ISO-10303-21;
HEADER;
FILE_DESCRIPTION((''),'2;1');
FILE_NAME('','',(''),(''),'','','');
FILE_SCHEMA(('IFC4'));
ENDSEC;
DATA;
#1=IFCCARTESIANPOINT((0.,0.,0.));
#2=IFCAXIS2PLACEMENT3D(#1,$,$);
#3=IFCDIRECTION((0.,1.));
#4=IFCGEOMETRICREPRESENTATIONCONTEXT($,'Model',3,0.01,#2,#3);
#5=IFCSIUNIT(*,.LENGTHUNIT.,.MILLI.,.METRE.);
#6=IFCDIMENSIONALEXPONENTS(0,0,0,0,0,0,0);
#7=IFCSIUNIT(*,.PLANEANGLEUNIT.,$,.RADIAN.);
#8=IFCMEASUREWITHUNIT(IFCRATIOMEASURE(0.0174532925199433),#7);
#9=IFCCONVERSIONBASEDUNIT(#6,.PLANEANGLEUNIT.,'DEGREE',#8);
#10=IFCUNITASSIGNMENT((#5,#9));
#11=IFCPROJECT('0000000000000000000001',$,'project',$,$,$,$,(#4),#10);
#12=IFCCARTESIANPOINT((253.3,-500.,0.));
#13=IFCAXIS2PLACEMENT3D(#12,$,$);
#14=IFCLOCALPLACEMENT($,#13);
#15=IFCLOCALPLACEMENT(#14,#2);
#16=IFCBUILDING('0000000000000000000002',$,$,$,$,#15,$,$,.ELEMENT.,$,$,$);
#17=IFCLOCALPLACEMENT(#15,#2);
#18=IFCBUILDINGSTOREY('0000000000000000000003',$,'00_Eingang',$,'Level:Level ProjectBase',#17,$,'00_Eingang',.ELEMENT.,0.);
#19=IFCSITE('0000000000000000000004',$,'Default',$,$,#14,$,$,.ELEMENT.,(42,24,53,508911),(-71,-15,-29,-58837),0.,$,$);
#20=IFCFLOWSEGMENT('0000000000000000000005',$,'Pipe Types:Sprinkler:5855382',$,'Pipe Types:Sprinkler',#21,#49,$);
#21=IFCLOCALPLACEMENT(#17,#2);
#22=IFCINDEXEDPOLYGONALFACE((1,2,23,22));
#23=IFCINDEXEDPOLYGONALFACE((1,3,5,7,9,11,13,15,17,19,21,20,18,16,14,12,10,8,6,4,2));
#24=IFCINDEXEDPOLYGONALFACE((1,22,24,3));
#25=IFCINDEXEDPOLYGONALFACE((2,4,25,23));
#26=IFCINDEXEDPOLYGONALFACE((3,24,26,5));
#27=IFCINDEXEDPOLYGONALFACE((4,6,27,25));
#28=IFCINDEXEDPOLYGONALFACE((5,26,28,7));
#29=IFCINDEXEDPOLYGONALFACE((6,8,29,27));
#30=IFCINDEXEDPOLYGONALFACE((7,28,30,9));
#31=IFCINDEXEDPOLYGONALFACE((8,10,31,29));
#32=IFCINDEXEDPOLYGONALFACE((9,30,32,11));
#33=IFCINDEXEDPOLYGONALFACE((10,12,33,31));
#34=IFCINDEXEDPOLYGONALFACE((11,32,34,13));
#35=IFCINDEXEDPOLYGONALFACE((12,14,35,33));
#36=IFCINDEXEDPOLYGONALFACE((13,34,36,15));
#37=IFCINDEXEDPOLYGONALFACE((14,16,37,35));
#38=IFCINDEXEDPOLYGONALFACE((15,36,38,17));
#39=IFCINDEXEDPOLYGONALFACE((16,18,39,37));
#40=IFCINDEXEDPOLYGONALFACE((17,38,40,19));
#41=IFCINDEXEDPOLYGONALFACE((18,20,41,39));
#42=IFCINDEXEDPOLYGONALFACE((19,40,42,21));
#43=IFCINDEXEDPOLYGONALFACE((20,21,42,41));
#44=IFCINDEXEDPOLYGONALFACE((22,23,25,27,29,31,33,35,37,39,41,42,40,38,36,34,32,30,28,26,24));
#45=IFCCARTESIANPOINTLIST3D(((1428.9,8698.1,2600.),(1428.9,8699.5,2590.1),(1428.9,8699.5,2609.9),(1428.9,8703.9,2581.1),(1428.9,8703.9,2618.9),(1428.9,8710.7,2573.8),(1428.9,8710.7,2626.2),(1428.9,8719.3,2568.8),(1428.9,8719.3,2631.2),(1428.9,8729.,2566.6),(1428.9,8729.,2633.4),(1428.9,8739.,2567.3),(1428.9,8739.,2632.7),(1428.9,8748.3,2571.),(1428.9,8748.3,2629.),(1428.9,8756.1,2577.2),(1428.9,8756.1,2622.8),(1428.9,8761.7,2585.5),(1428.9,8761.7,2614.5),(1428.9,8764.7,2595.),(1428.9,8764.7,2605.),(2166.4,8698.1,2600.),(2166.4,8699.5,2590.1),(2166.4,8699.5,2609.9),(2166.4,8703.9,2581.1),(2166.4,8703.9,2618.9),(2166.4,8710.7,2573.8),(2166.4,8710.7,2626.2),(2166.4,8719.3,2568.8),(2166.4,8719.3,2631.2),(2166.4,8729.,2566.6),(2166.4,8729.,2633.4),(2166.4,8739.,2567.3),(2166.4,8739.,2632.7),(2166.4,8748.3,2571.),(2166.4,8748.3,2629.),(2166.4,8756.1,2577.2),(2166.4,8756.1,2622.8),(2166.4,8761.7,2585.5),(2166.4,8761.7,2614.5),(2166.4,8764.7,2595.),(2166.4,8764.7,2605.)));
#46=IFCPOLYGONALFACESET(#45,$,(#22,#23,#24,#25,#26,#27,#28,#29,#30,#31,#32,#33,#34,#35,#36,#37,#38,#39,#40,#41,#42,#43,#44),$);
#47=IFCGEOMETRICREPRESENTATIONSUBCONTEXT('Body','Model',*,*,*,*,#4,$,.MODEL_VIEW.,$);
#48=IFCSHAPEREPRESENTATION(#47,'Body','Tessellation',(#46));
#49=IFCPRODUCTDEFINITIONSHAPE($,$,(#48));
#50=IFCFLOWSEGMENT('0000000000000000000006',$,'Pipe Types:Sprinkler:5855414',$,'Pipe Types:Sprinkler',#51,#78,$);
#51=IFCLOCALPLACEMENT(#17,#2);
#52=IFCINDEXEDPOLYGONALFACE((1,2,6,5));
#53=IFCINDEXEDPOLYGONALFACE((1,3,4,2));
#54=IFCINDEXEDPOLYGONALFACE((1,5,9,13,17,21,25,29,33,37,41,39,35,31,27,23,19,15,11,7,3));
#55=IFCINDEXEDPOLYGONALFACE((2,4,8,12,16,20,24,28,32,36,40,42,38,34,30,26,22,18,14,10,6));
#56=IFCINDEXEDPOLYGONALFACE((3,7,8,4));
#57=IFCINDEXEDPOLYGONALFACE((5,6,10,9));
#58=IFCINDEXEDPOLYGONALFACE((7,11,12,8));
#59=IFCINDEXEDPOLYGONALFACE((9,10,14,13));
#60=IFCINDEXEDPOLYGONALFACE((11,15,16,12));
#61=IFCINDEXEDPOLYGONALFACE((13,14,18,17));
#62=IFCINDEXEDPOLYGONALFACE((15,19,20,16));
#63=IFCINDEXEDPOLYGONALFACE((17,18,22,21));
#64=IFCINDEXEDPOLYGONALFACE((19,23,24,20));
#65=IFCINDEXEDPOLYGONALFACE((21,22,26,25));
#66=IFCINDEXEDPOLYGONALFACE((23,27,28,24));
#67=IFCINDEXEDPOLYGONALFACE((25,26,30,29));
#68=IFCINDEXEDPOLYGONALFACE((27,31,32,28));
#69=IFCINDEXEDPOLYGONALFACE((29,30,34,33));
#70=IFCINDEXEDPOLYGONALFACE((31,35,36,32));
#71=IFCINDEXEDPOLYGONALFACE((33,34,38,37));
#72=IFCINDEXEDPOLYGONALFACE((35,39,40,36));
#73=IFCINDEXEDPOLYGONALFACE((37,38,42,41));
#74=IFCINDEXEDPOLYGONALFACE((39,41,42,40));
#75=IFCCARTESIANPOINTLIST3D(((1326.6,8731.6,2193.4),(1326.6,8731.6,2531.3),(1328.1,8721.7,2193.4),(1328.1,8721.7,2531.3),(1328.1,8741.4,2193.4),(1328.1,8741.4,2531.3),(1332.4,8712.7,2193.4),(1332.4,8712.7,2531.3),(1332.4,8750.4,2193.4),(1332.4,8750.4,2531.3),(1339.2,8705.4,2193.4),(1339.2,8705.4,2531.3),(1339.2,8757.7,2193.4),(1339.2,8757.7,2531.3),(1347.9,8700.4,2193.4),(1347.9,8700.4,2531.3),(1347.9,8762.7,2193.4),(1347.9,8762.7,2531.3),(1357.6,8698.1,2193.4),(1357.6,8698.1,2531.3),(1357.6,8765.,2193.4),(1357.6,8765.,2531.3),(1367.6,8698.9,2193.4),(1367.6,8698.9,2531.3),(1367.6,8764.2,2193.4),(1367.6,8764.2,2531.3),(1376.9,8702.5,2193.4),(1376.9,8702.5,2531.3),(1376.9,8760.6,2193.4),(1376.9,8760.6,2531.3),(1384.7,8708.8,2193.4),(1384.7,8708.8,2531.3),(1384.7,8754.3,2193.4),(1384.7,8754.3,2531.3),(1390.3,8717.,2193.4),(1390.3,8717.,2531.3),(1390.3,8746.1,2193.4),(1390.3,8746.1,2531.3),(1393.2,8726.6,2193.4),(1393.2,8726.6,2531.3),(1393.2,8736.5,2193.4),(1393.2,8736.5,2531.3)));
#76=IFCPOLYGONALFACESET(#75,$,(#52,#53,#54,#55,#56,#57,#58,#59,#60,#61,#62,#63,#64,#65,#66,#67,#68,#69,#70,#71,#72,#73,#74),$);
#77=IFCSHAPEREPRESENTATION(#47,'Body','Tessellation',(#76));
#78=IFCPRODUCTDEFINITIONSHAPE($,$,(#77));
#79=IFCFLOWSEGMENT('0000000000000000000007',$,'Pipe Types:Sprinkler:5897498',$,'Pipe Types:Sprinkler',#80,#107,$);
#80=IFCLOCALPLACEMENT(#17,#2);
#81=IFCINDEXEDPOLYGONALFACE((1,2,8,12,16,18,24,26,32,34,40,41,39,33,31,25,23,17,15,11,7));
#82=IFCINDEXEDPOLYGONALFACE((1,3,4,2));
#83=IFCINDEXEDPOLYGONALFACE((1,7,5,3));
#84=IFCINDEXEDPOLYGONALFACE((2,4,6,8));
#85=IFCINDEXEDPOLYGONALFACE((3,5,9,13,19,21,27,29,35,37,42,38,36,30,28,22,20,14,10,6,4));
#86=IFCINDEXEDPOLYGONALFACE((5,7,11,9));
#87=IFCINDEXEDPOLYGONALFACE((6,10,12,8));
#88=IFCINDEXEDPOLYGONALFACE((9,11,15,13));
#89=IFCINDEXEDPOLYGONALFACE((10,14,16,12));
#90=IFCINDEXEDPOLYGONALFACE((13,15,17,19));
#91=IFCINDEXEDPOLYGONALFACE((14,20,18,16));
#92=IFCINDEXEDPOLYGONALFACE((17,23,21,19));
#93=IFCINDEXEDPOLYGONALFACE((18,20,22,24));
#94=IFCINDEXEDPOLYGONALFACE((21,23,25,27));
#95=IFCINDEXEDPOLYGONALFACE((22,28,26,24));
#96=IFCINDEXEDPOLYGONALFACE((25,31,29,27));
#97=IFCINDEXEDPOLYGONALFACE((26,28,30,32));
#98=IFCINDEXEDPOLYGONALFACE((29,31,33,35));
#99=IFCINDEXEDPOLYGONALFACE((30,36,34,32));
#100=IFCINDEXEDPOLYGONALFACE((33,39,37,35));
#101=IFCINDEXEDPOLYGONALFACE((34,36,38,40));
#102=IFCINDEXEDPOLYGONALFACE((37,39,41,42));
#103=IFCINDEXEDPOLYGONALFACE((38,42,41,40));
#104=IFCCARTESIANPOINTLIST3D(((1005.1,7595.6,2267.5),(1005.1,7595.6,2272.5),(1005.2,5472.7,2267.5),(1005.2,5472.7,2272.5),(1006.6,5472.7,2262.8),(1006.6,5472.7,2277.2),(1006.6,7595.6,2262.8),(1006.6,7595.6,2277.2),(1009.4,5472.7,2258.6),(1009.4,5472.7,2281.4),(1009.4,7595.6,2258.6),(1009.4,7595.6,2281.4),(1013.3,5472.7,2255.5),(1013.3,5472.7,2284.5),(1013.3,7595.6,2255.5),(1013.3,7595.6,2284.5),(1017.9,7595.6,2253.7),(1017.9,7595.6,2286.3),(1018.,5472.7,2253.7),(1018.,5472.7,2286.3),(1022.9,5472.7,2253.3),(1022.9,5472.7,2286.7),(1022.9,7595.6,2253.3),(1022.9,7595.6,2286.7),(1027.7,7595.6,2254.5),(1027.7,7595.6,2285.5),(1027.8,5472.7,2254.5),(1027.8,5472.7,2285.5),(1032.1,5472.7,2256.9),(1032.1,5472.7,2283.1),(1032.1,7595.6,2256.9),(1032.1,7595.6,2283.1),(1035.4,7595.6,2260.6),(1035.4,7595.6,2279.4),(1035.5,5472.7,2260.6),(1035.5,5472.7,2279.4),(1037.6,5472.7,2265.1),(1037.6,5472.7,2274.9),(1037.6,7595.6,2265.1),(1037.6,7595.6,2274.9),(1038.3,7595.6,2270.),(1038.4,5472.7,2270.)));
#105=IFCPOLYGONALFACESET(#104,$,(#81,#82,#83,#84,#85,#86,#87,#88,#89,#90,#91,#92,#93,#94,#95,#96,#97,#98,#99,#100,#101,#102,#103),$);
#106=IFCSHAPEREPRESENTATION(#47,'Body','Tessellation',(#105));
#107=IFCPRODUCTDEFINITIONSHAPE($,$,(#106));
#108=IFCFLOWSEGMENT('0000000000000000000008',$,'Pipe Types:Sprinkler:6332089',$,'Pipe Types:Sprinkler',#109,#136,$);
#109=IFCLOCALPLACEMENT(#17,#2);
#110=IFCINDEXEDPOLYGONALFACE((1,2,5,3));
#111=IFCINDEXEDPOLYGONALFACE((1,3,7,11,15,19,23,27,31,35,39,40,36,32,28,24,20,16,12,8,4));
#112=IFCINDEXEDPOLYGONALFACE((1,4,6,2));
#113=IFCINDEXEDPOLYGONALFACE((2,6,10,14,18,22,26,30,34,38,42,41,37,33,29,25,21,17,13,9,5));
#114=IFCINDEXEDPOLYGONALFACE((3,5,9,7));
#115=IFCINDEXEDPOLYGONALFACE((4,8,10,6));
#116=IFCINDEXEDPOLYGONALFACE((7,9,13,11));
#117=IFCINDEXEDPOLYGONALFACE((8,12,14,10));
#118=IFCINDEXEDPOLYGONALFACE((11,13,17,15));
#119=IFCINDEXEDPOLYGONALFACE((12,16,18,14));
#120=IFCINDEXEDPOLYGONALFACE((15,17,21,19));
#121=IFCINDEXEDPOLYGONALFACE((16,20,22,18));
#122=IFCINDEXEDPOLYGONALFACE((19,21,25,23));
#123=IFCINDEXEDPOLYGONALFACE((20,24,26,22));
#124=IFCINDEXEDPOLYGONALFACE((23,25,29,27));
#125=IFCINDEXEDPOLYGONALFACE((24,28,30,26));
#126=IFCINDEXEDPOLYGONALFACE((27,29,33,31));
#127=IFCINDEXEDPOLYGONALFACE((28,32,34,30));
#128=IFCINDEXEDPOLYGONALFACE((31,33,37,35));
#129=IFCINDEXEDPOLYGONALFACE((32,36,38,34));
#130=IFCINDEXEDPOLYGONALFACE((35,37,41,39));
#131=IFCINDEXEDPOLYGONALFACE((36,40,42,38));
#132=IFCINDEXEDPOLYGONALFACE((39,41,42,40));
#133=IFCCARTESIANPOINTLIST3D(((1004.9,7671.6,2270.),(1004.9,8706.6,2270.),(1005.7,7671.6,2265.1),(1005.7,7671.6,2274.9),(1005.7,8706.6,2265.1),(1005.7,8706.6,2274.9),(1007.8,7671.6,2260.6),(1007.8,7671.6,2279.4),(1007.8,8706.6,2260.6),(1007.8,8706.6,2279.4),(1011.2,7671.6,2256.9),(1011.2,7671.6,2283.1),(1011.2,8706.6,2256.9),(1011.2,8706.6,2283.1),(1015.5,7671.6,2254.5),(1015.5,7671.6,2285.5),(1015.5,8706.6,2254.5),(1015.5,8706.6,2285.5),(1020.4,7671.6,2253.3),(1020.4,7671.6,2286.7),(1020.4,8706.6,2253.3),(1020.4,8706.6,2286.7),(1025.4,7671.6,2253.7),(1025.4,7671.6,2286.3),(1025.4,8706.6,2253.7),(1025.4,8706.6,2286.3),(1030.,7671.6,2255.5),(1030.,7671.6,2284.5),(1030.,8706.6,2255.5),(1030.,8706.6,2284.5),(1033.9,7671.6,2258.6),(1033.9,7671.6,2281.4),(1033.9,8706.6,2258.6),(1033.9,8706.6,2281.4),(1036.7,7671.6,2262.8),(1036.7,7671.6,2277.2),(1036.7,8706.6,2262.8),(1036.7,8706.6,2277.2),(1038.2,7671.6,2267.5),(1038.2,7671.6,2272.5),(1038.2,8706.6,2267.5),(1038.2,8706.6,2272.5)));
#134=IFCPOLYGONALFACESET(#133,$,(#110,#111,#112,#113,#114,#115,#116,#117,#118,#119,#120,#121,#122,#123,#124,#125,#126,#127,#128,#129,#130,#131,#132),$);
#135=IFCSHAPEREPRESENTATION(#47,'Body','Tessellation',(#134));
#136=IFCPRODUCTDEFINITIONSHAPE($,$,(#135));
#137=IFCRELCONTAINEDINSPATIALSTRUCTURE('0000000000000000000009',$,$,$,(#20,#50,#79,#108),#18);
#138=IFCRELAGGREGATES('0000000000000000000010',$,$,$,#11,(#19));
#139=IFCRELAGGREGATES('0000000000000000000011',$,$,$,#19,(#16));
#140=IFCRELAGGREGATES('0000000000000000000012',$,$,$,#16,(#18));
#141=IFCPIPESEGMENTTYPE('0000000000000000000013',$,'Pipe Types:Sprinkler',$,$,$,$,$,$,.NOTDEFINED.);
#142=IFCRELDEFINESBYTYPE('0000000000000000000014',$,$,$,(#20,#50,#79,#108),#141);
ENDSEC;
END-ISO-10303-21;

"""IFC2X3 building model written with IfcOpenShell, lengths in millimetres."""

from ifc_helpers import new_model, entity, si_unit, converted_unit, direction, frame, frame_2d, origin, origin_2d_with_axis, place, context, subcontext, project, spatial, circle, extrude, type_object, element, save


model = new_model("IFC2X3")

# Units and contexts
model_context = context("Model", 3, precision=0.01, world=origin(), true_north=direction((0.0, 1.0)))
body_context = subcontext(model_context, "Body", "Model", "MODEL_VIEW")
ifc_project = project(units=[si_unit("LENGTHUNIT", "METRE", prefix="MILLI"), converted_unit("PLANEANGLEUNIT", "DEGREE", entity("IfcRatioMeasure", 0.0174532925199433), si_unit("PLANEANGLEUNIT", "RADIAN"), dimensions=[0, 0, 0, 0, 0, 0, 0])], contexts=[model_context])

# Site, building, storey
site_placement = place(None, frame((253.3, -500.0, 0.0)))
site = spatial("IfcSite", under=ifc_project, at=site_placement, Name="Default", CompositionType="ELEMENT", RefLatitude=(42, 24, 53, 508911), RefLongitude=(-71, -15, -29, -58837), RefElevation=0.0)
building_placement = place(site_placement, origin())
building = spatial("IfcBuilding", under=site, at=building_placement, CompositionType="ELEMENT")
storey_placement = place(building_placement, origin())
storey = spatial("IfcBuildingStorey", under=building, at=storey_placement, Name="00_Eingang", ObjectType="Level:Level ProjectBase", LongName="00_Eingang", CompositionType="ELEMENT", Elevation=0.0)

# Flow segments
pipe_segment_type = type_object("IfcPipeSegmentType", Name="Pipe Types:Sprinkler", PredefinedType="NOTDEFINED")
flow_segment_1_placement = place(storey_placement, frame((1428.9, 8696.5, 2564.9)))
element("IfcFlowSegment", 1, at=flow_segment_1_placement, inside=storey, type_object=pipe_segment_type, Name="Pipe Types:Sprinkler:5855382", ObjectType="Pipe Types:Sprinkler", context=body_context, shape_type="SweptSolid", body=[
    extrude(circle(Radius=33.5, at=origin_2d_with_axis()), frame((0.0, 35.1, 35.1), z_axis=(1.0, 0.0, -0.000009), x_axis=(0.0, -1.0, 0.0)), (0.0, 0.0, 1.0), 737.5),
])
flow_segment_2_placement = place(storey_placement, frame((1325.0, 8696.5, 2193.4)))
element("IfcFlowSegment", 2, at=flow_segment_2_placement, inside=storey, type_object=pipe_segment_type, Name="Pipe Types:Sprinkler:5855414", ObjectType="Pipe Types:Sprinkler", context=body_context, shape_type="SweptSolid", body=[
    extrude(circle(Radius=33.5, at=frame_2d((0.0, 0.0), x_axis=(1.0, 0.0))), frame((35.1, 35.1, 0.0), z_axis=(0.000012, 0.0, 1.0), x_axis=(-1.0, 0.0, 0.000012)), (0.0, 0.0, 1.0), 337.9),
])
flow_segment_3_placement = place(storey_placement, frame((1003.4, 5472.7, 2251.7)))
element("IfcFlowSegment", 3, at=flow_segment_3_placement, inside=storey, type_object=pipe_segment_type, Name="Pipe Types:Sprinkler:5897498", ObjectType="Pipe Types:Sprinkler", context=body_context, shape_type="SweptSolid", body=[
    extrude(circle(Radius=16.7, at=frame_2d((0.0, 0.0), x_axis=(1.0, 0.0))), frame((18.3, 0.0, 18.3), z_axis=(-0.000009, 1.0, 0.0), x_axis=(1.0, 0.000009, 0.0)), (0.0, 0.0, 1.0), 2122.8),
])
flow_segment_4_placement = place(storey_placement, frame((1003.3, 7671.6, 2251.7)))
element("IfcFlowSegment", 4, at=flow_segment_4_placement, inside=storey, type_object=pipe_segment_type, Name="Pipe Types:Sprinkler:6332089", ObjectType="Pipe Types:Sprinkler", context=body_context, shape_type="SweptSolid", body=[
    extrude(circle(Radius=16.7, at=frame_2d((0.0, 0.0), x_axis=(1.0, 0.0))), frame((18.3, 0.0, 18.3), z_axis=(-0.000009, 1.0, 0.0), x_axis=(-1.0, -0.000009, 0.0)), (0.0, 0.0, 1.0), 1035.0),
])

save(model, "model.ifc")
